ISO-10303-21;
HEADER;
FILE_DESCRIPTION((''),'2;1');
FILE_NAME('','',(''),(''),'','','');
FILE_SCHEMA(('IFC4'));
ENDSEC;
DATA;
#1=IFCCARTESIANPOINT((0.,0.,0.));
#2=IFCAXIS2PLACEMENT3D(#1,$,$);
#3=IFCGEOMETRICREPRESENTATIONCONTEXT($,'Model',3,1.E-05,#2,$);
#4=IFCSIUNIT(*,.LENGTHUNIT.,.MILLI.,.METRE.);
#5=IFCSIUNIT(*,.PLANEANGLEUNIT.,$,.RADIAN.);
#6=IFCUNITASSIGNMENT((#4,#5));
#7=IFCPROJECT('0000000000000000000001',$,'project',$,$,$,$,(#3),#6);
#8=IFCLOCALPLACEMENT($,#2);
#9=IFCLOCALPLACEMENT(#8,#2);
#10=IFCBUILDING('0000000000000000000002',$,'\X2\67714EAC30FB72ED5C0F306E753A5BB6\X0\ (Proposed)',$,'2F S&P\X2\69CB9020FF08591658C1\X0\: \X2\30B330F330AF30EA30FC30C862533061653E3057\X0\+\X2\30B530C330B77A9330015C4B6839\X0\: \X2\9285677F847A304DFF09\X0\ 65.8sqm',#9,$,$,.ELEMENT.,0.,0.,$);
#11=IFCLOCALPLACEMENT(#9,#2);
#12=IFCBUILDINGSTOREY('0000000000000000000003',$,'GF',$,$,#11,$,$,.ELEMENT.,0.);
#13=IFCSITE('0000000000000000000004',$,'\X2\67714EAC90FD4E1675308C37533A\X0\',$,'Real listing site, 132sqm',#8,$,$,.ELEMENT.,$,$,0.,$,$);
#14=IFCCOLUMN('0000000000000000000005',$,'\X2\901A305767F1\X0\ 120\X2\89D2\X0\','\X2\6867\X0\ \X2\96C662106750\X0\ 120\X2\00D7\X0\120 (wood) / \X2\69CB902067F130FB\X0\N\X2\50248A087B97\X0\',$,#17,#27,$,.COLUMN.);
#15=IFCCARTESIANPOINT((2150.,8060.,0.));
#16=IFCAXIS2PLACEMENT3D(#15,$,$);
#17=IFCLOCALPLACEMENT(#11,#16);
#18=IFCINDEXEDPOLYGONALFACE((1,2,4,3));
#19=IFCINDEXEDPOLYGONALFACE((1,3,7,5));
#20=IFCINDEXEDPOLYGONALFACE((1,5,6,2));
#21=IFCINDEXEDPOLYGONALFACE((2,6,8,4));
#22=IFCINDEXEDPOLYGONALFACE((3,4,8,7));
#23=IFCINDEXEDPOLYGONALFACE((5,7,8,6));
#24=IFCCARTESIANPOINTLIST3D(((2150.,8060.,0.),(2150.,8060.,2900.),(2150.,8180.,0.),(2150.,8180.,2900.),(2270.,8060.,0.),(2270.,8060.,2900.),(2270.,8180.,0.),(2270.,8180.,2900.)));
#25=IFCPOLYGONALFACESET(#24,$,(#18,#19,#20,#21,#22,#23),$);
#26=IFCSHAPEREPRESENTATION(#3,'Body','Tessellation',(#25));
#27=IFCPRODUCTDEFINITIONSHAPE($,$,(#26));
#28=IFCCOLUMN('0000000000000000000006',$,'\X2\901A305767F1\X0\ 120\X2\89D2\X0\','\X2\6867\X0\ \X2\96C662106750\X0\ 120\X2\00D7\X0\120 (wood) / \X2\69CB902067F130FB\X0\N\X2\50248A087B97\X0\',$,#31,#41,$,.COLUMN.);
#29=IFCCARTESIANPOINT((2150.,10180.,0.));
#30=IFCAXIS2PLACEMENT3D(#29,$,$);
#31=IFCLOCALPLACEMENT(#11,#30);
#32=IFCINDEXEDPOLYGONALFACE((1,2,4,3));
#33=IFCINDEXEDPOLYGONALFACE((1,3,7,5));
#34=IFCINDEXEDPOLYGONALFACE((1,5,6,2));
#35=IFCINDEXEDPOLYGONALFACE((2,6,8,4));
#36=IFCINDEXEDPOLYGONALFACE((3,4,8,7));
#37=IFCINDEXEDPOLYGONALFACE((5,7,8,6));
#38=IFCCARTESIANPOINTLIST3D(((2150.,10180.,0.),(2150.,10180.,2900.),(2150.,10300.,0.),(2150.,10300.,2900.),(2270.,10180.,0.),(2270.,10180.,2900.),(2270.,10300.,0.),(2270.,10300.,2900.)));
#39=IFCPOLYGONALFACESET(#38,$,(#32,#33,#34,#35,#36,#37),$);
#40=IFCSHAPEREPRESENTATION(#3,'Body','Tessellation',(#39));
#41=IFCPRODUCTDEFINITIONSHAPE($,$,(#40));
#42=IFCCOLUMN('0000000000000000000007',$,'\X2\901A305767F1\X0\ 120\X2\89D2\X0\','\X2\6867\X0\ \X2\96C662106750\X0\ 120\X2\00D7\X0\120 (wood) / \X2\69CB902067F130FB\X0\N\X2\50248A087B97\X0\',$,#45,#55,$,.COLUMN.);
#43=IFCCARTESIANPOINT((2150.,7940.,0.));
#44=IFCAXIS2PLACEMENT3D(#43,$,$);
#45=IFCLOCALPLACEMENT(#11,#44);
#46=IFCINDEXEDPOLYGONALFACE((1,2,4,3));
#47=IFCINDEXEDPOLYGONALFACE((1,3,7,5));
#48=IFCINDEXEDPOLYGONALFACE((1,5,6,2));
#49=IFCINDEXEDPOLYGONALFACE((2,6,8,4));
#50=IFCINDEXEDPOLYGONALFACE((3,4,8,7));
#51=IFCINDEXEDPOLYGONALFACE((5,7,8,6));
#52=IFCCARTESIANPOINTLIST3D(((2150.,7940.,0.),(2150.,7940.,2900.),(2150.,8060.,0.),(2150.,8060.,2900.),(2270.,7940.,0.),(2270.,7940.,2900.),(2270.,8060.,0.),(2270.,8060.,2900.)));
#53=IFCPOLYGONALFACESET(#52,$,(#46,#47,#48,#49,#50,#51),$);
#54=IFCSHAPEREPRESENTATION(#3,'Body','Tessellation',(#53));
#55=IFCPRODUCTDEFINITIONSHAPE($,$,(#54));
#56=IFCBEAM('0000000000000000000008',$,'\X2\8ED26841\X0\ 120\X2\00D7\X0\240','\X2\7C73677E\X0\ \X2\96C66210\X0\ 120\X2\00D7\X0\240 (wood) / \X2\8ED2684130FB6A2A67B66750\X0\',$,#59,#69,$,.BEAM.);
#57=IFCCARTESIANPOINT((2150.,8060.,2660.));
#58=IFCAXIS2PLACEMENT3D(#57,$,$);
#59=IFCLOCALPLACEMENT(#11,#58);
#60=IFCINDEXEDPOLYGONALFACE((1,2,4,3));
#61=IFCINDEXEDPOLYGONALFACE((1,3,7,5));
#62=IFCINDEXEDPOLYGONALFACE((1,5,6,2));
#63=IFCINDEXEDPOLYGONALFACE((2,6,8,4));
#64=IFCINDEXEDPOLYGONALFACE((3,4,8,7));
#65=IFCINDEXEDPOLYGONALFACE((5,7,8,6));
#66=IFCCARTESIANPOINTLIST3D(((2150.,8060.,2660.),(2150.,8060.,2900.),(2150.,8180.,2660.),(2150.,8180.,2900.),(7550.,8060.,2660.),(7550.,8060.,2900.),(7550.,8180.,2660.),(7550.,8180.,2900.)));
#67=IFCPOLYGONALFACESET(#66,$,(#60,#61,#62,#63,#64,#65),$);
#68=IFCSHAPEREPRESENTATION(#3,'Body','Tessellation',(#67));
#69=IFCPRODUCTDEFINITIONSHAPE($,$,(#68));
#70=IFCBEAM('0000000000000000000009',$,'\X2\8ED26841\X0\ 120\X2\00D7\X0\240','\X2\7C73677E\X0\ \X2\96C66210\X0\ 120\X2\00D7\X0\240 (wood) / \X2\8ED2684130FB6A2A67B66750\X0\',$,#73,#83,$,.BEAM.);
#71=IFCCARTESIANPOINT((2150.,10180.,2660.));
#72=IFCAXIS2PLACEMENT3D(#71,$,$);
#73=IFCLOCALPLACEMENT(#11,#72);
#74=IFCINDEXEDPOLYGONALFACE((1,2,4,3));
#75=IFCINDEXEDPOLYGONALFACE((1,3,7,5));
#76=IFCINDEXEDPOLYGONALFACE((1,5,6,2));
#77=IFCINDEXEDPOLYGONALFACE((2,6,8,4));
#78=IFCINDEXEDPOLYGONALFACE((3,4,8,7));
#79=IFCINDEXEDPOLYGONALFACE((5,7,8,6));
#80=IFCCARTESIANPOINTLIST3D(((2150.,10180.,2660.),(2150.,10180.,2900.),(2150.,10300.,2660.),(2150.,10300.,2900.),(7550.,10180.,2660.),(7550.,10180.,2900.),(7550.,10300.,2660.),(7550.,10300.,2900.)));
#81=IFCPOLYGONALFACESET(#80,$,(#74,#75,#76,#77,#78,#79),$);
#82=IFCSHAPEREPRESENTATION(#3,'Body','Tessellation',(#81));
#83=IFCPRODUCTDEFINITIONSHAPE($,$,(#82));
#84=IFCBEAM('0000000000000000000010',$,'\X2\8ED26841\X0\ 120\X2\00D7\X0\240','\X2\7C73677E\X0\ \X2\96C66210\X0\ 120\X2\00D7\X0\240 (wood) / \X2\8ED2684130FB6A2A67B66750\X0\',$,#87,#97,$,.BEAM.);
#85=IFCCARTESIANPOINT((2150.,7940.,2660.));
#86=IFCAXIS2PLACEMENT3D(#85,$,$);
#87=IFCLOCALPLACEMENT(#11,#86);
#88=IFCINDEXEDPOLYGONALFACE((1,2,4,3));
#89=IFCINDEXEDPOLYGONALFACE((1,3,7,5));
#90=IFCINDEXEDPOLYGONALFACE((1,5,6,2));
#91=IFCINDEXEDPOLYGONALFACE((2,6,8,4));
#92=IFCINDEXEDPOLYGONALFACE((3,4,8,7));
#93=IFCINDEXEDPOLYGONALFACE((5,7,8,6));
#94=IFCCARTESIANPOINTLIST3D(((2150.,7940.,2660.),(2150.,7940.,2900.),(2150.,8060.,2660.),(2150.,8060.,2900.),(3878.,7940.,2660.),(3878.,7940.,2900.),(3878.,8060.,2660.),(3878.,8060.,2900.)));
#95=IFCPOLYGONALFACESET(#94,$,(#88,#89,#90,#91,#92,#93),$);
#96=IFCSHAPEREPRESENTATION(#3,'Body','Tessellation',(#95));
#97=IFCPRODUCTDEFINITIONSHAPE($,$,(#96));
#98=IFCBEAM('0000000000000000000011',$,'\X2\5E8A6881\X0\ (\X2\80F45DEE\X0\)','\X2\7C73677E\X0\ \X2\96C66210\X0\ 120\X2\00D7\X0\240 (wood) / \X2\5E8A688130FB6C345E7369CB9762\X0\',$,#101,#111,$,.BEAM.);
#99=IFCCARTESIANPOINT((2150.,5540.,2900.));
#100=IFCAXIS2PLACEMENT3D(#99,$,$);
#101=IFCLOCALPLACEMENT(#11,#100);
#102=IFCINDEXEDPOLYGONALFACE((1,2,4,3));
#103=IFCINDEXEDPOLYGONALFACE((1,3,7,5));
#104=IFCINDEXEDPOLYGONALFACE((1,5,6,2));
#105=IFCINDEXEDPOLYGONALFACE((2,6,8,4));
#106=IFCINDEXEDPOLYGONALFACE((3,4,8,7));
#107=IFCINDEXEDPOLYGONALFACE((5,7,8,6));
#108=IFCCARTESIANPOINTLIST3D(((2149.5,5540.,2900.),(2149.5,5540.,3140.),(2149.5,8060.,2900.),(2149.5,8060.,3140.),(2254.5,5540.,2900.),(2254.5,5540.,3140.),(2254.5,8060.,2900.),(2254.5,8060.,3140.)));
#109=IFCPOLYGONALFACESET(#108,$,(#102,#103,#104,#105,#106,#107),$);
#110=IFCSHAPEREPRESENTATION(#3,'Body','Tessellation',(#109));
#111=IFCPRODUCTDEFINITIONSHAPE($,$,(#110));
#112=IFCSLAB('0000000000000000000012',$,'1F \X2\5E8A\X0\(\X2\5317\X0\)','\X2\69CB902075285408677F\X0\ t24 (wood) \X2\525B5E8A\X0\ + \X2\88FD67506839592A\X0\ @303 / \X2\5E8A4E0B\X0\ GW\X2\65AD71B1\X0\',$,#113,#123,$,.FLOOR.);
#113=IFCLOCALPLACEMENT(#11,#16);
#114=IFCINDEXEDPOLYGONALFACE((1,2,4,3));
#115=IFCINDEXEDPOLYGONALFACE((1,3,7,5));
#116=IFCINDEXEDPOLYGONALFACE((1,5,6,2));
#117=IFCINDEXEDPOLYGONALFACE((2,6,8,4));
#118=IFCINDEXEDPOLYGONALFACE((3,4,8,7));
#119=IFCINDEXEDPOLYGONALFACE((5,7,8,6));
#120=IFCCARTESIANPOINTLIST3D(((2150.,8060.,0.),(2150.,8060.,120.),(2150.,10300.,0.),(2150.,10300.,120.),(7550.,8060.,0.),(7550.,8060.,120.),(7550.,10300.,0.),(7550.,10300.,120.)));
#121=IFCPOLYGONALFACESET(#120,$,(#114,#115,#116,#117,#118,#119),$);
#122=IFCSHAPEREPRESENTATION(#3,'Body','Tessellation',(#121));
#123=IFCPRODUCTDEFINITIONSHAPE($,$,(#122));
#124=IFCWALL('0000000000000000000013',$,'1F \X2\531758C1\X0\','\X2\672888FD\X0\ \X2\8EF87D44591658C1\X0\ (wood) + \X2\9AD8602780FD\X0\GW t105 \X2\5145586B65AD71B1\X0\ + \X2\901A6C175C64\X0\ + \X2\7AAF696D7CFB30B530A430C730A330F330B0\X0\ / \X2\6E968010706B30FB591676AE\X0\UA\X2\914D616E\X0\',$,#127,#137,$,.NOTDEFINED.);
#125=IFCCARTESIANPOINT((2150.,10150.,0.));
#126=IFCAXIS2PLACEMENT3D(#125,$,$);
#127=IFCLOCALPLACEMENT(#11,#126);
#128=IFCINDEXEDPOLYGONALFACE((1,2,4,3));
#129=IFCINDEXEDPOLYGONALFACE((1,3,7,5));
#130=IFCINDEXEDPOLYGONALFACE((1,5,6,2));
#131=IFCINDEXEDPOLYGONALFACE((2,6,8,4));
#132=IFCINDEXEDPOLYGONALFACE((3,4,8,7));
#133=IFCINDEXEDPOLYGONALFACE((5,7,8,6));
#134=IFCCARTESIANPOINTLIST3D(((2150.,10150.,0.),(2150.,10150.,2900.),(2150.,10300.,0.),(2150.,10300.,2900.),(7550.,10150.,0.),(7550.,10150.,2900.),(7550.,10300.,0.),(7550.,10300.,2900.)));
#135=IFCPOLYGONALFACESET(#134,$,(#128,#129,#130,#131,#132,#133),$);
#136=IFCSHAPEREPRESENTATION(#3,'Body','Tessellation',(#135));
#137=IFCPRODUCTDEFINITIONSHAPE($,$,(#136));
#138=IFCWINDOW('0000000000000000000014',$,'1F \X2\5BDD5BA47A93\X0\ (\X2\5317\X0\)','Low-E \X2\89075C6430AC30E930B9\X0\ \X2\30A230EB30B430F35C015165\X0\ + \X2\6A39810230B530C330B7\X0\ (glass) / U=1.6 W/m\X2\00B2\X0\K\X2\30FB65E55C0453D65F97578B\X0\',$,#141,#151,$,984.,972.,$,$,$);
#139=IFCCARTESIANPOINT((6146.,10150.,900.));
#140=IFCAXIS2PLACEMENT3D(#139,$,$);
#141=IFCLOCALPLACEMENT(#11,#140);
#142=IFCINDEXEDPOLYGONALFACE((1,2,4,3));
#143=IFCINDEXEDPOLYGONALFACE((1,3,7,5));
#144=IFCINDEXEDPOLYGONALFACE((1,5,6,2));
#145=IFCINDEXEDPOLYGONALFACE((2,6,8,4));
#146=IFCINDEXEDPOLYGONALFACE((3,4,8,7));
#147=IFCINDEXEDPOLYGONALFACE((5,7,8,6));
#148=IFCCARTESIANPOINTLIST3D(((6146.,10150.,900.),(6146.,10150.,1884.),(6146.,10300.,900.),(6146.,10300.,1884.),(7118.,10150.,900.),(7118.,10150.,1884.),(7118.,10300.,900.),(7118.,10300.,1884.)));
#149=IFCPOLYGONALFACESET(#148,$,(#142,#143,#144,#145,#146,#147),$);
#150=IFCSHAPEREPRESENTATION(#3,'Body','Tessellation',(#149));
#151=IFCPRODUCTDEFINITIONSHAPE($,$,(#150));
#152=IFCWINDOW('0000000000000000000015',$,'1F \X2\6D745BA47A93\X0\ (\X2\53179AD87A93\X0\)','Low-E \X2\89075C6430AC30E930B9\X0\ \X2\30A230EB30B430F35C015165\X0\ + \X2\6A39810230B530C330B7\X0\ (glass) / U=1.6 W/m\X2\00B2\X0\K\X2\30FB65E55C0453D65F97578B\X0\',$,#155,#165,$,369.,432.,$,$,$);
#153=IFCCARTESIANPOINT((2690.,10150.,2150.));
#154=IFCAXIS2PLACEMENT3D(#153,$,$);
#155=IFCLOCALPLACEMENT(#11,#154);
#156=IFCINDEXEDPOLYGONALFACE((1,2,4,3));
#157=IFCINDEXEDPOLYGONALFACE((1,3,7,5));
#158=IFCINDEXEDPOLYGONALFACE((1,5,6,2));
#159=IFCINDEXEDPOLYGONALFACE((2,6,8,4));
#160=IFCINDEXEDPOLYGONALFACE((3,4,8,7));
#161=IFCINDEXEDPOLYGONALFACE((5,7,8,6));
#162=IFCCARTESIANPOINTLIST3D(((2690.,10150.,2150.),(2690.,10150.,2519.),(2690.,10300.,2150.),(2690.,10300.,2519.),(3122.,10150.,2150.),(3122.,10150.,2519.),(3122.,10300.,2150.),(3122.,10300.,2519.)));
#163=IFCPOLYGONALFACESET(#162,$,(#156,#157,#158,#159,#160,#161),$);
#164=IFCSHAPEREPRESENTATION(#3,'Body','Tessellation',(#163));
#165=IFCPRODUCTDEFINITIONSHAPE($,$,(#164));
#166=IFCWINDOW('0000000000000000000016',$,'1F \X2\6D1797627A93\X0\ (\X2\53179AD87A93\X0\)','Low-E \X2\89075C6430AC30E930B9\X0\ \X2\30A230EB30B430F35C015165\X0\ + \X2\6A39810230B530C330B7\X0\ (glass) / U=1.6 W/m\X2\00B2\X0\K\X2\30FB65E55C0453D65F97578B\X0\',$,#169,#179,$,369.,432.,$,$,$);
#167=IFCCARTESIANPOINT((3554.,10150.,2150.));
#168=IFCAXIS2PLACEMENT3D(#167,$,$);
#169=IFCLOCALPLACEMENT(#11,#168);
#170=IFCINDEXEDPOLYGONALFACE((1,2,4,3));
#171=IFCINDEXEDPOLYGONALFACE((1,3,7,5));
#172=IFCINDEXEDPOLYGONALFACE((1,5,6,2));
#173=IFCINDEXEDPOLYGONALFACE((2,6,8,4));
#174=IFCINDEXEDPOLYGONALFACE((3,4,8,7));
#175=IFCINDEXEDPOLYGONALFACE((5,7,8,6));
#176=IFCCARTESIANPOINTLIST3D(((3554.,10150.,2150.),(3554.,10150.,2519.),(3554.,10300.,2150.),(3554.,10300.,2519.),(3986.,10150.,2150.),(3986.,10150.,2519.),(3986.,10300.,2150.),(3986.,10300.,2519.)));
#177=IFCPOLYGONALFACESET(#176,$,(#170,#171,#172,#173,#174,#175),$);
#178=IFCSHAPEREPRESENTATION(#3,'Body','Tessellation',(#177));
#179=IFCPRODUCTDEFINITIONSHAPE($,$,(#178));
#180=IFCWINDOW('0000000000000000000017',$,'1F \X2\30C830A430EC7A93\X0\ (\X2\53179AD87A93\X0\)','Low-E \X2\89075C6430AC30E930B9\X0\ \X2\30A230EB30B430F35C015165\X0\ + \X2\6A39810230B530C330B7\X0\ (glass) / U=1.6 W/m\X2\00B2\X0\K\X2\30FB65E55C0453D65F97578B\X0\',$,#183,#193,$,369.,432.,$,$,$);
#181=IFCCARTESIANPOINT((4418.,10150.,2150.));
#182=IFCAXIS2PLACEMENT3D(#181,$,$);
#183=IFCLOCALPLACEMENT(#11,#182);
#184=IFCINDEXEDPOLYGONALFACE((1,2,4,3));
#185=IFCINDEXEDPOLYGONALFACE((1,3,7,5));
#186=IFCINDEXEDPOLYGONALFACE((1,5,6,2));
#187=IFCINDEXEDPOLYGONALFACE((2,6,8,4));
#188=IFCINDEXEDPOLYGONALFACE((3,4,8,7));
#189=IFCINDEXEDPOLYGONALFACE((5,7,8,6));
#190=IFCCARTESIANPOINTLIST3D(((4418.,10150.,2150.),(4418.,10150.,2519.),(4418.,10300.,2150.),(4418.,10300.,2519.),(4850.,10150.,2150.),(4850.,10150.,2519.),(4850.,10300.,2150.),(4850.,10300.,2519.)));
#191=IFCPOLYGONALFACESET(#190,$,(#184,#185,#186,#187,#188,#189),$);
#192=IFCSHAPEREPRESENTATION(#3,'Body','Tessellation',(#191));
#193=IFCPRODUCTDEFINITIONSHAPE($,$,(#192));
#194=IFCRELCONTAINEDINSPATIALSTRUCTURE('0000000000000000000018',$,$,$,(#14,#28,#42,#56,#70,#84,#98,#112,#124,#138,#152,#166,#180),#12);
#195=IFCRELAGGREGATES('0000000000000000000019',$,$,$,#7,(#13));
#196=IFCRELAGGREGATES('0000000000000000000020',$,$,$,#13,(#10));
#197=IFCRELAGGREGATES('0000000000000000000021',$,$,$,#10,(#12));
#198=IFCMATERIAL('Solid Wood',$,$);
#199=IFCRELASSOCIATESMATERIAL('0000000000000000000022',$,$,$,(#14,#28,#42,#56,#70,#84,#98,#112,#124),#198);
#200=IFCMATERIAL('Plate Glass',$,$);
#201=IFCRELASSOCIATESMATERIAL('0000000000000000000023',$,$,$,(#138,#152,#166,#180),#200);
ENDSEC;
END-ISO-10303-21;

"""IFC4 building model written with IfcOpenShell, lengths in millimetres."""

from ifc_helpers import new_model, si_unit, frame, frame_2d, origin, place, context, project, spatial, rectangle, extrude, material, element, fill, save


model = new_model("IFC4")

# Units and contexts
model_context = context("Model", 3, precision=1e-05, world=origin())
ifc_project = project(units=[si_unit("LENGTHUNIT", "METRE", prefix="MILLI"), si_unit("PLANEANGLEUNIT", "RADIAN")], contexts=[model_context])

# Site, building, storey
site_placement = place(None, origin())
site = spatial("IfcSite", under=ifc_project, at=site_placement, Name="東京都世田谷区", ObjectType="Real listing site, 132sqm", CompositionType="ELEMENT", RefElevation=0.0)
building_placement = place(site_placement, origin())
building = spatial("IfcBuilding", under=site, at=building_placement, Name="東京・狭小の町家 (Proposed)", ObjectType="2F S&P構造（外壁: コンクリート打ち放し+サッシ窓、屋根: 銅板葺き） 65.8sqm", CompositionType="ELEMENT", ElevationOfRefHeight=0.0, ElevationOfTerrain=0.0)
storey_placement = place(building_placement, origin())
storey = spatial("IfcBuildingStorey", under=building, at=storey_placement, Name="GF", CompositionType="ELEMENT", Elevation=0.0)

# Columns
ifc_material_1 = material(Name="Solid Wood")
column_1_placement = place(storey_placement, frame((2150.0, 8060.0, 0.0)))
element("IfcColumn", 1, at=column_1_placement, inside=storey, material=ifc_material_1, Name="通し柱 120角", Description="桧 集成材 120×120 (wood) / 構造柱・N値計算", PredefinedType="COLUMN", context=model_context, shape_type="SweptSolid", body=[
    extrude(rectangle(XDim=120.0, YDim=120.0, at=frame_2d((60.0, 60.0))), frame((2150.0, 8060.0, 0.0)), (0.0, 0.0, 1.0), 2900.0),
])
column_2_placement = place(storey_placement, frame((2150.0, 10180.0, 0.0)))
element("IfcColumn", 2, at=column_2_placement, inside=storey, material=ifc_material_1, Name="通し柱 120角", Description="桧 集成材 120×120 (wood) / 構造柱・N値計算", PredefinedType="COLUMN", context=model_context, shape_type="SweptSolid", body=[
    extrude(rectangle(XDim=120.0, YDim=120.0, at=frame_2d((60.0, 60.0))), frame((2150.0, 10180.0, 0.0)), (0.0, 0.0, 1.0), 2900.0),
])
column_3_placement = place(storey_placement, frame((2150.0, 7940.0, 0.0)))
element("IfcColumn", 3, at=column_3_placement, inside=storey, material=ifc_material_1, Name="通し柱 120角", Description="桧 集成材 120×120 (wood) / 構造柱・N値計算", PredefinedType="COLUMN", context=model_context, shape_type="SweptSolid", body=[
    extrude(rectangle(XDim=120.0, YDim=120.0, at=frame_2d((60.0, 60.0))), frame((2150.0, 7940.0, 0.0)), (0.0, 0.0, 1.0), 2900.0),
])

# Beams
beam_1_placement = place(storey_placement, frame((2150.0, 8060.0, 2660.0)))
element("IfcBeam", 4, at=beam_1_placement, inside=storey, material=ifc_material_1, Name="軒桁 120×240", Description="米松 集成 120×240 (wood) / 軒桁・横架材", PredefinedType="BEAM", context=model_context, shape_type="SweptSolid", body=[
    extrude(rectangle(XDim=5400.0, YDim=120.0, at=frame_2d((2700.0, 60.0))), frame((2150.0, 8060.0, 2660.0)), (0.0, 0.0, 1.0), 240.0),
])
beam_2_placement = place(storey_placement, frame((2150.0, 10180.0, 2660.0)))
element("IfcBeam", 5, at=beam_2_placement, inside=storey, material=ifc_material_1, Name="軒桁 120×240", Description="米松 集成 120×240 (wood) / 軒桁・横架材", PredefinedType="BEAM", context=model_context, shape_type="SweptSolid", body=[
    extrude(rectangle(XDim=5400.0, YDim=120.0, at=frame_2d((2700.0, 60.0))), frame((2150.0, 10180.0, 2660.0)), (0.0, 0.0, 1.0), 240.0),
])
beam_3_placement = place(storey_placement, frame((2150.0, 7940.0, 2660.0)))
element("IfcBeam", 6, at=beam_3_placement, inside=storey, material=ifc_material_1, Name="軒桁 120×240", Description="米松 集成 120×240 (wood) / 軒桁・横架材", PredefinedType="BEAM", context=model_context, shape_type="SweptSolid", body=[
    extrude(rectangle(XDim=1728.0, YDim=120.0, at=frame_2d((864.0, 60.0))), frame((2150.0, 7940.0, 2660.0)), (0.0, 0.0, 1.0), 240.0),
])
beam_4_placement = place(storey_placement, frame((2150.0, 5540.0, 2900.0)))
element("IfcBeam", 7, at=beam_4_placement, inside=storey, material=ifc_material_1, Name="床梁 (胴差)", Description="米松 集成 120×240 (wood) / 床梁・水平構面", PredefinedType="BEAM", context=model_context, shape_type="SweptSolid", body=[
    extrude(rectangle(XDim=105.0, YDim=2520.0, at=frame_2d((52.0, 1260.0))), frame((2150.0, 5540.0, 2900.0)), (0.0, 0.0, 1.0), 240.0),
])

# Slab
slab_placement = place(storey_placement, frame((2150.0, 8060.0, 0.0)))
element("IfcSlab", 8, at=slab_placement, inside=storey, material=ifc_material_1, Name="1F 床(北)", Description="構造用合板 t24 (wood) 剛床 + 製材根太 @303 / 床下 GW断熱", PredefinedType="FLOOR", context=model_context, shape_type="SweptSolid", body=[
    extrude(rectangle(XDim=5400.0, YDim=2240.0, at=frame_2d((2700.0, 1120.0))), frame((2150.0, 8060.0, 0.0)), (0.0, 0.0, 1.0), 120.0),
])

# Wall, openings, windows
wall_1_placement = place(storey_placement, frame((2150.0, 10150.0, 0.0)))
wall_1 = element("IfcWall", 9, at=wall_1_placement, inside=storey, material=ifc_material_1, Name="1F 北壁", Description="木製 軸組外壁 (wood) + 高性能GW t105 充填断熱 + 通気層 + 窯業系サイディング / 準耐火・外皮UA配慮", PredefinedType="NOTDEFINED", context=model_context, shape_type="SweptSolid", body=[
    extrude(rectangle(XDim=5400.0, YDim=150.0, at=frame_2d((2700.0, 75.0))), frame((2150.0, 10150.0, 0.0)), (0.0, 0.0, 1.0), 2900.0),
])
opening_1_placement = place(storey_placement, frame((6146.0, 10150.0, 900.0)))
opening_1 = element("IfcOpeningElement", 10, at=opening_1_placement, cuts=wall_1, PredefinedType="NOTDEFINED", context=model_context, shape_type="SweptSolid", body=[
    extrude(rectangle(XDim=972.0, YDim=150.0, at=frame_2d((486.0, 75.0))), frame((6146.0, 10150.0, 900.0)), (0.0, 0.0, 1.0), 984.0),
])
opening_2_placement = place(storey_placement, frame((2690.0, 10150.0, 2150.0)))
opening_2 = element("IfcOpeningElement", 11, at=opening_2_placement, cuts=wall_1, PredefinedType="NOTDEFINED", context=model_context, shape_type="SweptSolid", body=[
    extrude(rectangle(XDim=432.0, YDim=150.0, at=frame_2d((216.0, 75.0))), frame((2690.0, 10150.0, 2150.0)), (0.0, 0.0, 1.0), 369.0),
])
opening_3_placement = place(storey_placement, frame((3554.0, 10150.0, 2150.0)))
opening_3 = element("IfcOpeningElement", 12, at=opening_3_placement, cuts=wall_1, PredefinedType="NOTDEFINED", context=model_context, shape_type="SweptSolid", body=[
    extrude(rectangle(XDim=432.0, YDim=150.0, at=frame_2d((216.0, 75.0))), frame((3554.0, 10150.0, 2150.0)), (0.0, 0.0, 1.0), 369.0),
])
opening_4_placement = place(storey_placement, frame((4418.0, 10150.0, 2150.0)))
opening_4 = element("IfcOpeningElement", 13, at=opening_4_placement, cuts=wall_1, PredefinedType="NOTDEFINED", context=model_context, shape_type="SweptSolid", body=[
    extrude(rectangle(XDim=432.0, YDim=150.0, at=frame_2d((216.0, 75.0))), frame((4418.0, 10150.0, 2150.0)), (0.0, 0.0, 1.0), 369.0),
])
ifc_material_2 = material(Name="Plate Glass")
window_1_placement = place(storey_placement, frame((6146.0, 10150.0, 900.0)))
window_1 = element("IfcWindow", 14, at=window_1_placement, inside=storey, material=ifc_material_2, Name="1F 寝室窓 (北)", Description="Low-E 複層ガラス アルゴン封入 + 樹脂サッシ (glass) / U=1.6 W/m²K・日射取得型", OverallHeight=984.0, OverallWidth=972.0, context=model_context, shape_type="SweptSolid", body=[
    extrude(rectangle(XDim=972.0, YDim=150.0, at=frame_2d((486.0, 75.0))), frame((6146.0, 10150.0, 900.0)), (0.0, 0.0, 1.0), 984.0),
])
fill(opening_1, window_1)
window_2_placement = place(storey_placement, frame((2690.0, 10150.0, 2150.0)))
window_2 = element("IfcWindow", 15, at=window_2_placement, inside=storey, material=ifc_material_2, Name="1F 浴室窓 (北高窓)", Description="Low-E 複層ガラス アルゴン封入 + 樹脂サッシ (glass) / U=1.6 W/m²K・日射取得型", OverallHeight=369.0, OverallWidth=432.0, context=model_context, shape_type="SweptSolid", body=[
    extrude(rectangle(XDim=432.0, YDim=150.0, at=frame_2d((216.0, 75.0))), frame((2690.0, 10150.0, 2150.0)), (0.0, 0.0, 1.0), 369.0),
])
fill(opening_2, window_2)
window_3_placement = place(storey_placement, frame((3554.0, 10150.0, 2150.0)))
window_3 = element("IfcWindow", 16, at=window_3_placement, inside=storey, material=ifc_material_2, Name="1F 洗面窓 (北高窓)", Description="Low-E 複層ガラス アルゴン封入 + 樹脂サッシ (glass) / U=1.6 W/m²K・日射取得型", OverallHeight=369.0, OverallWidth=432.0, context=model_context, shape_type="SweptSolid", body=[
    extrude(rectangle(XDim=432.0, YDim=150.0, at=frame_2d((216.0, 75.0))), frame((3554.0, 10150.0, 2150.0)), (0.0, 0.0, 1.0), 369.0),
])
fill(opening_3, window_3)
window_4_placement = place(storey_placement, frame((4418.0, 10150.0, 2150.0)))
window_4 = element("IfcWindow", 17, at=window_4_placement, inside=storey, material=ifc_material_2, Name="1F トイレ窓 (北高窓)", Description="Low-E 複層ガラス アルゴン封入 + 樹脂サッシ (glass) / U=1.6 W/m²K・日射取得型", OverallHeight=369.0, OverallWidth=432.0, context=model_context, shape_type="SweptSolid", body=[
    extrude(rectangle(XDim=432.0, YDim=150.0, at=frame_2d((216.0, 75.0))), frame((4418.0, 10150.0, 2150.0)), (0.0, 0.0, 1.0), 369.0),
])
fill(opening_4, window_4)

save(model, "model.ifc")
